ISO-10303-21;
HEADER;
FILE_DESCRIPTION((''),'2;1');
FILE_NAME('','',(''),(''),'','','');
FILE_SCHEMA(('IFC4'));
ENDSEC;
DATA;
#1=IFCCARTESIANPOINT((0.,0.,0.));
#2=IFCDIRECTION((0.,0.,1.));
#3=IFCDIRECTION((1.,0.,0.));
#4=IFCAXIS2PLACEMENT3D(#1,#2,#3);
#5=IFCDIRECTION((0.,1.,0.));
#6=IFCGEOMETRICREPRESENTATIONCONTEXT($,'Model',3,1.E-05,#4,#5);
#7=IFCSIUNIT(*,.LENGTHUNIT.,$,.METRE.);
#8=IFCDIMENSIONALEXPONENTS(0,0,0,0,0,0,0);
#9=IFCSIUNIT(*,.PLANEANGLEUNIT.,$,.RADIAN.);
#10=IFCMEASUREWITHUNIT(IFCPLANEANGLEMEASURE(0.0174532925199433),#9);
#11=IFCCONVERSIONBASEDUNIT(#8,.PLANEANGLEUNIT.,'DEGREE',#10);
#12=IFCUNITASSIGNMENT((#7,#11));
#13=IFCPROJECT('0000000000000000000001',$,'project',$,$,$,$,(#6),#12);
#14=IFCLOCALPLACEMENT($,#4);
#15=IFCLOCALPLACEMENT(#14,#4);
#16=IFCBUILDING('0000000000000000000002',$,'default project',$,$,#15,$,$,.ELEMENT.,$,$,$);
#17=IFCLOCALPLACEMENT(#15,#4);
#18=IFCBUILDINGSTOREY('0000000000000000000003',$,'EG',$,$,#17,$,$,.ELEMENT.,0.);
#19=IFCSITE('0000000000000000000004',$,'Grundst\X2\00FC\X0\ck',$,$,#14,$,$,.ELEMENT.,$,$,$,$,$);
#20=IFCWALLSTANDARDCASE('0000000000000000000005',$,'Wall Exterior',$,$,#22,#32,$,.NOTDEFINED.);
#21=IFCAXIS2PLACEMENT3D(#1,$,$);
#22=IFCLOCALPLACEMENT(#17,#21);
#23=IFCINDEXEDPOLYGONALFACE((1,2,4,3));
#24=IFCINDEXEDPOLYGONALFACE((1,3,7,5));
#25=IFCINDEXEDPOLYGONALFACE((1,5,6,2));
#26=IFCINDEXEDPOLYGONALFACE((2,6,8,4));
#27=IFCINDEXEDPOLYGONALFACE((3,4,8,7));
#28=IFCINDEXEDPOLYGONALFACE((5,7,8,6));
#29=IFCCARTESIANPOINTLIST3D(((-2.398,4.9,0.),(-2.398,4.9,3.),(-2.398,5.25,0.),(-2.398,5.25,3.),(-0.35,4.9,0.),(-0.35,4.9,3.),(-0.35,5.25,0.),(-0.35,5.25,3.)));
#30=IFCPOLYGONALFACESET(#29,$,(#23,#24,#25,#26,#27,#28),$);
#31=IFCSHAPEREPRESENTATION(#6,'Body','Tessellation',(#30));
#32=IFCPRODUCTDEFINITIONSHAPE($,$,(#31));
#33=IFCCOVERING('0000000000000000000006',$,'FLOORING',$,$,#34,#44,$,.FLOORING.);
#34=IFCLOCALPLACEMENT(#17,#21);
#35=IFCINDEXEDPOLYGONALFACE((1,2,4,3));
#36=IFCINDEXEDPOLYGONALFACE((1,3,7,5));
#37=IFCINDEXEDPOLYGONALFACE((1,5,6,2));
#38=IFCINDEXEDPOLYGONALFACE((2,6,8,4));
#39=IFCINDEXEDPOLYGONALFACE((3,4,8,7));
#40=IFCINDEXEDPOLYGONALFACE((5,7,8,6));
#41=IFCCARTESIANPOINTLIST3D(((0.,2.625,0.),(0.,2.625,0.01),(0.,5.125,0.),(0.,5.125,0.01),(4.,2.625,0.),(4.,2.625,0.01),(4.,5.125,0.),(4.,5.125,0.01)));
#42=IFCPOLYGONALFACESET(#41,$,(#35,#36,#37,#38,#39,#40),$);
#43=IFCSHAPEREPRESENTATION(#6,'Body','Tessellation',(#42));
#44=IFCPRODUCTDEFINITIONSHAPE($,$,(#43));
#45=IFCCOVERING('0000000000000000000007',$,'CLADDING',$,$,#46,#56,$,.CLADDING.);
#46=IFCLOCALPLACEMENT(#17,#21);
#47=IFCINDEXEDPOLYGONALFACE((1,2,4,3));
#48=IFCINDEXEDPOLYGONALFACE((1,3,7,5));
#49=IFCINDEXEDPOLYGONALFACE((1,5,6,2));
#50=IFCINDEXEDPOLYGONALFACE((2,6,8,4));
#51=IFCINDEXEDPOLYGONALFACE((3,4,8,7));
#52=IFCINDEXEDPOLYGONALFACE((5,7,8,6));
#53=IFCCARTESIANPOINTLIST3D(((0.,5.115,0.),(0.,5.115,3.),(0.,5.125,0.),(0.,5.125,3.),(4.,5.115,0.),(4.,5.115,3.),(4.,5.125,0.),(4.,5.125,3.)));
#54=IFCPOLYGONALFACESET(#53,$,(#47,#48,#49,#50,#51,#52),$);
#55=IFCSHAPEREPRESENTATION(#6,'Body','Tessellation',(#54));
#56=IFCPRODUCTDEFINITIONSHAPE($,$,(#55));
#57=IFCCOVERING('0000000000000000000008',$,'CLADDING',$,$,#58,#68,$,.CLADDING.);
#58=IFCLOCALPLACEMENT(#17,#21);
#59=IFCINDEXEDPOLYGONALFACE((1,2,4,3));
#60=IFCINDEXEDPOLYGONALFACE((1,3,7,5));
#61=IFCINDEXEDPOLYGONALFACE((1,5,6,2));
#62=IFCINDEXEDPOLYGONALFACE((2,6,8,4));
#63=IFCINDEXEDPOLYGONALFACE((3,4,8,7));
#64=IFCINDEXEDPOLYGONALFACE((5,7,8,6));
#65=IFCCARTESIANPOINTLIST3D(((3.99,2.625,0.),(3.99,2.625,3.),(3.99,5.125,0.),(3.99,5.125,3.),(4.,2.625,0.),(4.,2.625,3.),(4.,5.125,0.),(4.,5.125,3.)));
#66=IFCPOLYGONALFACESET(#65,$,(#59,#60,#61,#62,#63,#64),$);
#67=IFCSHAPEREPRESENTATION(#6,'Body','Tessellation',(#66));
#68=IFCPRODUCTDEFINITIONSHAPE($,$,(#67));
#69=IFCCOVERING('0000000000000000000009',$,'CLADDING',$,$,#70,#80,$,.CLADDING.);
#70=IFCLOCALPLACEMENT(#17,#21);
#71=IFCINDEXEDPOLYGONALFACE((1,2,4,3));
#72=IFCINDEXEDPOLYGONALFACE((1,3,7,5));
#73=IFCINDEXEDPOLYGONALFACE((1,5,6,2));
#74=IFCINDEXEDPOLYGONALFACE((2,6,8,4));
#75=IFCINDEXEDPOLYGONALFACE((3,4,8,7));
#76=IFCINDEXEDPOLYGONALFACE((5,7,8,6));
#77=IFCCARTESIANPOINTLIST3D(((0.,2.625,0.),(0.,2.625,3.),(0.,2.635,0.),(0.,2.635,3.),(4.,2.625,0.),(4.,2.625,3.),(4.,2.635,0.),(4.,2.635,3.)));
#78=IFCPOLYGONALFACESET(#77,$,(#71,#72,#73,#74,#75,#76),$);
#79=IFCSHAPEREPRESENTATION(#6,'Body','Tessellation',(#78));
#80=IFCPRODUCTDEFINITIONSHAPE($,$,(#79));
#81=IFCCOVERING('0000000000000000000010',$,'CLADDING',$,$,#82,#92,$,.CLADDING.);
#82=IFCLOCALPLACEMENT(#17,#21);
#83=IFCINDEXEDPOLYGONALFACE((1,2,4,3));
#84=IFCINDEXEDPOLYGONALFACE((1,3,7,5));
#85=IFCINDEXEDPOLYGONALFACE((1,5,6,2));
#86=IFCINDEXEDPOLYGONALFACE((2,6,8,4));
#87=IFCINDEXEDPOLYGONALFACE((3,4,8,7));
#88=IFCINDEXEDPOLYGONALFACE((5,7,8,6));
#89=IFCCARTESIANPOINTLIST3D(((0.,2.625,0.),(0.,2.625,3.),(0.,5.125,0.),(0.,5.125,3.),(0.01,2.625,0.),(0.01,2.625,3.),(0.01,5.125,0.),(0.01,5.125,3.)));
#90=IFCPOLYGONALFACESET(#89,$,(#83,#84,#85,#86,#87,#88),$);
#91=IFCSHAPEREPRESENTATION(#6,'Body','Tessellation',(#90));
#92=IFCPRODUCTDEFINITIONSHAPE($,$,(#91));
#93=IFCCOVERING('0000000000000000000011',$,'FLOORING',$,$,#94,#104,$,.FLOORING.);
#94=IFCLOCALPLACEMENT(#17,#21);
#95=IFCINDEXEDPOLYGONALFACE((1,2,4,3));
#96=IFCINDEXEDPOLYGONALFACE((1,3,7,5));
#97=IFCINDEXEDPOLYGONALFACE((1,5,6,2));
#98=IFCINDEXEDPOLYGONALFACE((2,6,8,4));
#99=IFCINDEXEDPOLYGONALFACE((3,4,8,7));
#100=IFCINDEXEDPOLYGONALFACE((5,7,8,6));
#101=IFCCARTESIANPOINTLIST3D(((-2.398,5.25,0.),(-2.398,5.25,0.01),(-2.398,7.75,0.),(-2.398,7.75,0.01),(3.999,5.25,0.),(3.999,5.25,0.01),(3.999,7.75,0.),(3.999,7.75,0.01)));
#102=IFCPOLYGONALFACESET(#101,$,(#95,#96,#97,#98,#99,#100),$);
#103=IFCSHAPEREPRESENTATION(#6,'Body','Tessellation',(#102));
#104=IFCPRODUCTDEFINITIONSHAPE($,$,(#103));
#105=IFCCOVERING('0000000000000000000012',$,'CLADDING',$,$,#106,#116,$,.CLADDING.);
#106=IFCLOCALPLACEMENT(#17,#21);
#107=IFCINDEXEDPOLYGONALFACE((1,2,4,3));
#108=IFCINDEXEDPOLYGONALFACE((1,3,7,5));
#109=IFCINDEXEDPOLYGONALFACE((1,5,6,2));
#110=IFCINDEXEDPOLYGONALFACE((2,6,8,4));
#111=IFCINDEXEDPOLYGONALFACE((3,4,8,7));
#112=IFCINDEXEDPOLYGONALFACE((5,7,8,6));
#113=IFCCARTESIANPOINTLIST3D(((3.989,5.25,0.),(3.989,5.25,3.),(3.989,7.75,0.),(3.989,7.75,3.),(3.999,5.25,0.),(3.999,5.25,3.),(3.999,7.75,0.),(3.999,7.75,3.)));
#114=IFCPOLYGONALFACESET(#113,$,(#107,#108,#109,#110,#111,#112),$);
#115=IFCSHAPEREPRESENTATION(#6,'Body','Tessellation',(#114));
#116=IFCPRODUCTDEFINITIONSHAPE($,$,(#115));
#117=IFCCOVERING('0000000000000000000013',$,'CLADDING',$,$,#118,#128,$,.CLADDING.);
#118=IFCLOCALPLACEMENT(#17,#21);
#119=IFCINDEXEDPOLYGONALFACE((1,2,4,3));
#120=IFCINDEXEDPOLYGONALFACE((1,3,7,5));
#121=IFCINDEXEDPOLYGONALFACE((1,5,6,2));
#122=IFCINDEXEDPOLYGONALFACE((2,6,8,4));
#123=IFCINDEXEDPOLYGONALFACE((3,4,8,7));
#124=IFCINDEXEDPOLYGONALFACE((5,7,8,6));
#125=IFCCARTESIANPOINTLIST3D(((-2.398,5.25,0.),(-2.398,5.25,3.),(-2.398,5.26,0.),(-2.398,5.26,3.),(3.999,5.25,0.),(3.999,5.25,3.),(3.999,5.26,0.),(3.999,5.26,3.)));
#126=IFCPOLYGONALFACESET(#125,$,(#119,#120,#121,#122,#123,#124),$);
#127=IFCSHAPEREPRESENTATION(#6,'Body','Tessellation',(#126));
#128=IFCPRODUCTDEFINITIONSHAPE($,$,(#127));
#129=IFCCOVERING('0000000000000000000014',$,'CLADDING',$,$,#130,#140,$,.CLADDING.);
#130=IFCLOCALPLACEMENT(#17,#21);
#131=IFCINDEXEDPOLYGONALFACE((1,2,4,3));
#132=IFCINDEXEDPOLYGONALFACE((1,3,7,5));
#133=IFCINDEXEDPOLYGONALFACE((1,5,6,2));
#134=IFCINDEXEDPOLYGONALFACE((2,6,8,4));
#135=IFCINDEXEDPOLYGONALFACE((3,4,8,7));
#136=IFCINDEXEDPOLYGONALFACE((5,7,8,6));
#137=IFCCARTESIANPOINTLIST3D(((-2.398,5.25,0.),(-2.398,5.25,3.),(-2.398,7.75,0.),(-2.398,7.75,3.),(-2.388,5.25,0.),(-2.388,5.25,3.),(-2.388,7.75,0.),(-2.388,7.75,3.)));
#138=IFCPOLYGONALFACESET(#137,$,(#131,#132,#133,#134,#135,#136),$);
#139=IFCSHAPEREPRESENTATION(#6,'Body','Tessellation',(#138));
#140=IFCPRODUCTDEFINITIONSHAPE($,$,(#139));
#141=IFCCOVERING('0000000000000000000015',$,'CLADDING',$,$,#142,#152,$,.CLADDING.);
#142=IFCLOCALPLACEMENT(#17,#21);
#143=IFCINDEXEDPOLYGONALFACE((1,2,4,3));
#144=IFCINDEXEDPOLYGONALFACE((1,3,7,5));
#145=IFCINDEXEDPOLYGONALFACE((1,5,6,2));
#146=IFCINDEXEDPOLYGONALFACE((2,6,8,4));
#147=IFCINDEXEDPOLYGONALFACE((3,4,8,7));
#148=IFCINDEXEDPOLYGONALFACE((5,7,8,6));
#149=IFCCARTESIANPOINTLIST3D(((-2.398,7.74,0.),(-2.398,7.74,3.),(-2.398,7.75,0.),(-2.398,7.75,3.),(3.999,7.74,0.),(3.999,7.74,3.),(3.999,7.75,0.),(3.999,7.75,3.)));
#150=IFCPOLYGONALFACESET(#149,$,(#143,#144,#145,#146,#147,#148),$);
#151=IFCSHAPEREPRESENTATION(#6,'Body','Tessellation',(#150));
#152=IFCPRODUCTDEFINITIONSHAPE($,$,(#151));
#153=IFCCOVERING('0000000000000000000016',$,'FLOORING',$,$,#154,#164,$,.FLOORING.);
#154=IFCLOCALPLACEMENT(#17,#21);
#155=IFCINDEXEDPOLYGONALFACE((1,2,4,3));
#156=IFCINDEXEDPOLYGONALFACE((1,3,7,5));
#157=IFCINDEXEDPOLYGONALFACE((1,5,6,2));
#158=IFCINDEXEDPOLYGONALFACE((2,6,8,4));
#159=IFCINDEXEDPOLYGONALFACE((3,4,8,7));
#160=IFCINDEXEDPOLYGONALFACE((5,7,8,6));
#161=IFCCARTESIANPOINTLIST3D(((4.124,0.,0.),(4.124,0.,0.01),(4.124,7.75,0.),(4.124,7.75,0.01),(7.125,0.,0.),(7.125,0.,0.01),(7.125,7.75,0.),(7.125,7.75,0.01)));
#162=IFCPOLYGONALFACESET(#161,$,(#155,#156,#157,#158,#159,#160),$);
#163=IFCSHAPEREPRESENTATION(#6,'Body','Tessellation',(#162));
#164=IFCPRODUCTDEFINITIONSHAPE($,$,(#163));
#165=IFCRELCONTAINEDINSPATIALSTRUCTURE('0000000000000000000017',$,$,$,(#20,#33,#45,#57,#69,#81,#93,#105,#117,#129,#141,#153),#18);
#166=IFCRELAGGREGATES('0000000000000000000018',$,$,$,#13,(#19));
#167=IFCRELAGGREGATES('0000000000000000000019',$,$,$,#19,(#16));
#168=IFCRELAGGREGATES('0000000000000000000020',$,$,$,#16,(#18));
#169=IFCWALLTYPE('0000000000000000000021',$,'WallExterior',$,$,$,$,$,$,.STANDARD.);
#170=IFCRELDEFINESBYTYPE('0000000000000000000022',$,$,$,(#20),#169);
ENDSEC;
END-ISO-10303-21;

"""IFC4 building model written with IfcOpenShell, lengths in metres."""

from ifc_helpers import new_model, entity, si_unit, converted_unit, direction, frame, origin_with_axes, place, context, project, spatial, polyline, outline, extrude, type_object, element, save


model = new_model("IFC4")

# Units and contexts
model_context = context("Model", 3, precision=1e-05, world=origin_with_axes(), true_north=direction((0.0, 1.0, 0.0)))
ifc_project = project(units=[si_unit("LENGTHUNIT", "METRE"), converted_unit("PLANEANGLEUNIT", "DEGREE", entity("IfcPlaneAngleMeasure", 0.0174532925199433), si_unit("PLANEANGLEUNIT", "RADIAN"), dimensions=[0, 0, 0, 0, 0, 0, 0])], contexts=[model_context])

# Site, building, storey
site_placement = place(None, origin_with_axes())
site = spatial("IfcSite", under=ifc_project, at=site_placement, Name="Grundstück", CompositionType="ELEMENT")
building_placement = place(site_placement, origin_with_axes())
building = spatial("IfcBuilding", under=site, at=building_placement, Name="default project", CompositionType="ELEMENT")
placement_1 = place(building_placement, origin_with_axes())
storey = spatial("IfcBuildingStorey", under=building, at=placement_1, Name="EG", CompositionType="ELEMENT", Elevation=0.0)

# Wall
wall_type_1 = type_object("IfcWallType", Name="WallExterior", PredefinedType="STANDARD")
placement_2 = place(placement_1, frame((-0.175, 5.075, 0.0), z_axis=(0.0, 0.0, 1.0), x_axis=(-1.0, 0.0, 0.0)))
element("IfcWallStandardCase", 1, at=placement_2, inside=storey, type_object=wall_type_1, Name="Wall Exterior", PredefinedType="NOTDEFINED", context=model_context, shape_type="SweptSolid", body=[
    extrude(outline(polyline([(0.175, -0.175), (2.223, -0.175), (2.223, 0.175), (0.175, 0.175), (0.175, -0.175)])), origin_with_axes(), (0.0, 0.0, 1.0), 3.0),
])

# Coverings
element("IfcCovering", 2, at=placement_1, inside=storey, Name="FLOORING", PredefinedType="FLOORING", context=model_context, shape_type="SweptSolid", body=[
    extrude(outline(polyline([(4.0, 5.125), (0.0, 5.125), (0.0, 2.625), (4.0, 2.625), (4.0, 5.125)])), origin_with_axes(), (0.0, 0.0, 1.0), 0.01),
])
element("IfcCovering", 3, at=placement_1, inside=storey, Name="CLADDING", PredefinedType="CLADDING", context=model_context, shape_type="SweptSolid", body=[
    extrude(outline(polyline([(0.0, 5.115), (4.0, 5.115), (4.0, 5.125), (0.0, 5.125), (0.0, 5.115)])), origin_with_axes(), (0.0, 0.0, 1.0), 3.0),
])
element("IfcCovering", 4, at=placement_1, inside=storey, Name="CLADDING", PredefinedType="CLADDING", context=model_context, shape_type="SweptSolid", body=[
    extrude(outline(polyline([(3.99, 5.125), (3.99, 2.625), (4.0, 2.625), (4.0, 5.125), (3.99, 5.125)])), origin_with_axes(), (0.0, 0.0, 1.0), 3.0),
])
element("IfcCovering", 5, at=placement_1, inside=storey, Name="CLADDING", PredefinedType="CLADDING", context=model_context, shape_type="SweptSolid", body=[
    extrude(outline(polyline([(4.0, 2.635), (0.0, 2.635), (0.0, 2.625), (4.0, 2.625), (4.0, 2.635)])), origin_with_axes(), (0.0, 0.0, 1.0), 3.0),
])
element("IfcCovering", 6, at=placement_1, inside=storey, Name="CLADDING", PredefinedType="CLADDING", context=model_context, shape_type="SweptSolid", body=[
    extrude(outline(polyline([(0.01, 2.625), (0.01, 5.125), (0.0, 5.125), (0.0, 2.625), (0.01, 2.625)])), origin_with_axes(), (0.0, 0.0, 1.0), 3.0),
])
element("IfcCovering", 7, at=placement_1, inside=storey, Name="FLOORING", PredefinedType="FLOORING", context=model_context, shape_type="SweptSolid", body=[
    extrude(outline(polyline([(3.999, 7.75), (-2.398, 7.75), (-2.398, 5.25), (3.999, 5.25), (3.999, 7.75)])), origin_with_axes(), (0.0, 0.0, 1.0), 0.01),
])
element("IfcCovering", 8, at=placement_1, inside=storey, Name="CLADDING", PredefinedType="CLADDING", context=model_context, shape_type="SweptSolid", body=[
    extrude(outline(polyline([(3.989, 7.75), (3.989, 5.25), (3.999, 5.25), (3.999, 7.75), (3.989, 7.75)])), origin_with_axes(), (0.0, 0.0, 1.0), 3.0),
])
element("IfcCovering", 9, at=placement_1, inside=storey, Name="CLADDING", PredefinedType="CLADDING", context=model_context, shape_type="SweptSolid", body=[
    extrude(outline(polyline([(3.999, 5.26), (-2.398, 5.26), (-2.398, 5.25), (3.999, 5.25), (3.999, 5.26)])), origin_with_axes(), (0.0, 0.0, 1.0), 3.0),
])
element("IfcCovering", 10, at=placement_1, inside=storey, Name="CLADDING", PredefinedType="CLADDING", context=model_context, shape_type="SweptSolid", body=[
    extrude(outline(polyline([(-2.388, 5.25), (-2.388, 7.75), (-2.398, 7.75), (-2.398, 5.25), (-2.388, 5.25)])), origin_with_axes(), (0.0, 0.0, 1.0), 3.0),
])
element("IfcCovering", 11, at=placement_1, inside=storey, Name="CLADDING", PredefinedType="CLADDING", context=model_context, shape_type="SweptSolid", body=[
    extrude(outline(polyline([(-2.398, 7.74), (3.999, 7.74), (3.999, 7.75), (-2.398, 7.75), (-2.398, 7.74)])), origin_with_axes(), (0.0, 0.0, 1.0), 3.0),
])
element("IfcCovering", 12, at=placement_1, inside=storey, Name="FLOORING", PredefinedType="FLOORING", context=model_context, shape_type="SweptSolid", body=[
    extrude(outline(polyline([(7.125, 7.75), (4.124, 7.75), (4.124, 0.0), (7.125, 0.0), (7.125, 7.75)])), origin_with_axes(), (0.0, 0.0, 1.0), 0.01),
])

save(model, "model.ifc")
